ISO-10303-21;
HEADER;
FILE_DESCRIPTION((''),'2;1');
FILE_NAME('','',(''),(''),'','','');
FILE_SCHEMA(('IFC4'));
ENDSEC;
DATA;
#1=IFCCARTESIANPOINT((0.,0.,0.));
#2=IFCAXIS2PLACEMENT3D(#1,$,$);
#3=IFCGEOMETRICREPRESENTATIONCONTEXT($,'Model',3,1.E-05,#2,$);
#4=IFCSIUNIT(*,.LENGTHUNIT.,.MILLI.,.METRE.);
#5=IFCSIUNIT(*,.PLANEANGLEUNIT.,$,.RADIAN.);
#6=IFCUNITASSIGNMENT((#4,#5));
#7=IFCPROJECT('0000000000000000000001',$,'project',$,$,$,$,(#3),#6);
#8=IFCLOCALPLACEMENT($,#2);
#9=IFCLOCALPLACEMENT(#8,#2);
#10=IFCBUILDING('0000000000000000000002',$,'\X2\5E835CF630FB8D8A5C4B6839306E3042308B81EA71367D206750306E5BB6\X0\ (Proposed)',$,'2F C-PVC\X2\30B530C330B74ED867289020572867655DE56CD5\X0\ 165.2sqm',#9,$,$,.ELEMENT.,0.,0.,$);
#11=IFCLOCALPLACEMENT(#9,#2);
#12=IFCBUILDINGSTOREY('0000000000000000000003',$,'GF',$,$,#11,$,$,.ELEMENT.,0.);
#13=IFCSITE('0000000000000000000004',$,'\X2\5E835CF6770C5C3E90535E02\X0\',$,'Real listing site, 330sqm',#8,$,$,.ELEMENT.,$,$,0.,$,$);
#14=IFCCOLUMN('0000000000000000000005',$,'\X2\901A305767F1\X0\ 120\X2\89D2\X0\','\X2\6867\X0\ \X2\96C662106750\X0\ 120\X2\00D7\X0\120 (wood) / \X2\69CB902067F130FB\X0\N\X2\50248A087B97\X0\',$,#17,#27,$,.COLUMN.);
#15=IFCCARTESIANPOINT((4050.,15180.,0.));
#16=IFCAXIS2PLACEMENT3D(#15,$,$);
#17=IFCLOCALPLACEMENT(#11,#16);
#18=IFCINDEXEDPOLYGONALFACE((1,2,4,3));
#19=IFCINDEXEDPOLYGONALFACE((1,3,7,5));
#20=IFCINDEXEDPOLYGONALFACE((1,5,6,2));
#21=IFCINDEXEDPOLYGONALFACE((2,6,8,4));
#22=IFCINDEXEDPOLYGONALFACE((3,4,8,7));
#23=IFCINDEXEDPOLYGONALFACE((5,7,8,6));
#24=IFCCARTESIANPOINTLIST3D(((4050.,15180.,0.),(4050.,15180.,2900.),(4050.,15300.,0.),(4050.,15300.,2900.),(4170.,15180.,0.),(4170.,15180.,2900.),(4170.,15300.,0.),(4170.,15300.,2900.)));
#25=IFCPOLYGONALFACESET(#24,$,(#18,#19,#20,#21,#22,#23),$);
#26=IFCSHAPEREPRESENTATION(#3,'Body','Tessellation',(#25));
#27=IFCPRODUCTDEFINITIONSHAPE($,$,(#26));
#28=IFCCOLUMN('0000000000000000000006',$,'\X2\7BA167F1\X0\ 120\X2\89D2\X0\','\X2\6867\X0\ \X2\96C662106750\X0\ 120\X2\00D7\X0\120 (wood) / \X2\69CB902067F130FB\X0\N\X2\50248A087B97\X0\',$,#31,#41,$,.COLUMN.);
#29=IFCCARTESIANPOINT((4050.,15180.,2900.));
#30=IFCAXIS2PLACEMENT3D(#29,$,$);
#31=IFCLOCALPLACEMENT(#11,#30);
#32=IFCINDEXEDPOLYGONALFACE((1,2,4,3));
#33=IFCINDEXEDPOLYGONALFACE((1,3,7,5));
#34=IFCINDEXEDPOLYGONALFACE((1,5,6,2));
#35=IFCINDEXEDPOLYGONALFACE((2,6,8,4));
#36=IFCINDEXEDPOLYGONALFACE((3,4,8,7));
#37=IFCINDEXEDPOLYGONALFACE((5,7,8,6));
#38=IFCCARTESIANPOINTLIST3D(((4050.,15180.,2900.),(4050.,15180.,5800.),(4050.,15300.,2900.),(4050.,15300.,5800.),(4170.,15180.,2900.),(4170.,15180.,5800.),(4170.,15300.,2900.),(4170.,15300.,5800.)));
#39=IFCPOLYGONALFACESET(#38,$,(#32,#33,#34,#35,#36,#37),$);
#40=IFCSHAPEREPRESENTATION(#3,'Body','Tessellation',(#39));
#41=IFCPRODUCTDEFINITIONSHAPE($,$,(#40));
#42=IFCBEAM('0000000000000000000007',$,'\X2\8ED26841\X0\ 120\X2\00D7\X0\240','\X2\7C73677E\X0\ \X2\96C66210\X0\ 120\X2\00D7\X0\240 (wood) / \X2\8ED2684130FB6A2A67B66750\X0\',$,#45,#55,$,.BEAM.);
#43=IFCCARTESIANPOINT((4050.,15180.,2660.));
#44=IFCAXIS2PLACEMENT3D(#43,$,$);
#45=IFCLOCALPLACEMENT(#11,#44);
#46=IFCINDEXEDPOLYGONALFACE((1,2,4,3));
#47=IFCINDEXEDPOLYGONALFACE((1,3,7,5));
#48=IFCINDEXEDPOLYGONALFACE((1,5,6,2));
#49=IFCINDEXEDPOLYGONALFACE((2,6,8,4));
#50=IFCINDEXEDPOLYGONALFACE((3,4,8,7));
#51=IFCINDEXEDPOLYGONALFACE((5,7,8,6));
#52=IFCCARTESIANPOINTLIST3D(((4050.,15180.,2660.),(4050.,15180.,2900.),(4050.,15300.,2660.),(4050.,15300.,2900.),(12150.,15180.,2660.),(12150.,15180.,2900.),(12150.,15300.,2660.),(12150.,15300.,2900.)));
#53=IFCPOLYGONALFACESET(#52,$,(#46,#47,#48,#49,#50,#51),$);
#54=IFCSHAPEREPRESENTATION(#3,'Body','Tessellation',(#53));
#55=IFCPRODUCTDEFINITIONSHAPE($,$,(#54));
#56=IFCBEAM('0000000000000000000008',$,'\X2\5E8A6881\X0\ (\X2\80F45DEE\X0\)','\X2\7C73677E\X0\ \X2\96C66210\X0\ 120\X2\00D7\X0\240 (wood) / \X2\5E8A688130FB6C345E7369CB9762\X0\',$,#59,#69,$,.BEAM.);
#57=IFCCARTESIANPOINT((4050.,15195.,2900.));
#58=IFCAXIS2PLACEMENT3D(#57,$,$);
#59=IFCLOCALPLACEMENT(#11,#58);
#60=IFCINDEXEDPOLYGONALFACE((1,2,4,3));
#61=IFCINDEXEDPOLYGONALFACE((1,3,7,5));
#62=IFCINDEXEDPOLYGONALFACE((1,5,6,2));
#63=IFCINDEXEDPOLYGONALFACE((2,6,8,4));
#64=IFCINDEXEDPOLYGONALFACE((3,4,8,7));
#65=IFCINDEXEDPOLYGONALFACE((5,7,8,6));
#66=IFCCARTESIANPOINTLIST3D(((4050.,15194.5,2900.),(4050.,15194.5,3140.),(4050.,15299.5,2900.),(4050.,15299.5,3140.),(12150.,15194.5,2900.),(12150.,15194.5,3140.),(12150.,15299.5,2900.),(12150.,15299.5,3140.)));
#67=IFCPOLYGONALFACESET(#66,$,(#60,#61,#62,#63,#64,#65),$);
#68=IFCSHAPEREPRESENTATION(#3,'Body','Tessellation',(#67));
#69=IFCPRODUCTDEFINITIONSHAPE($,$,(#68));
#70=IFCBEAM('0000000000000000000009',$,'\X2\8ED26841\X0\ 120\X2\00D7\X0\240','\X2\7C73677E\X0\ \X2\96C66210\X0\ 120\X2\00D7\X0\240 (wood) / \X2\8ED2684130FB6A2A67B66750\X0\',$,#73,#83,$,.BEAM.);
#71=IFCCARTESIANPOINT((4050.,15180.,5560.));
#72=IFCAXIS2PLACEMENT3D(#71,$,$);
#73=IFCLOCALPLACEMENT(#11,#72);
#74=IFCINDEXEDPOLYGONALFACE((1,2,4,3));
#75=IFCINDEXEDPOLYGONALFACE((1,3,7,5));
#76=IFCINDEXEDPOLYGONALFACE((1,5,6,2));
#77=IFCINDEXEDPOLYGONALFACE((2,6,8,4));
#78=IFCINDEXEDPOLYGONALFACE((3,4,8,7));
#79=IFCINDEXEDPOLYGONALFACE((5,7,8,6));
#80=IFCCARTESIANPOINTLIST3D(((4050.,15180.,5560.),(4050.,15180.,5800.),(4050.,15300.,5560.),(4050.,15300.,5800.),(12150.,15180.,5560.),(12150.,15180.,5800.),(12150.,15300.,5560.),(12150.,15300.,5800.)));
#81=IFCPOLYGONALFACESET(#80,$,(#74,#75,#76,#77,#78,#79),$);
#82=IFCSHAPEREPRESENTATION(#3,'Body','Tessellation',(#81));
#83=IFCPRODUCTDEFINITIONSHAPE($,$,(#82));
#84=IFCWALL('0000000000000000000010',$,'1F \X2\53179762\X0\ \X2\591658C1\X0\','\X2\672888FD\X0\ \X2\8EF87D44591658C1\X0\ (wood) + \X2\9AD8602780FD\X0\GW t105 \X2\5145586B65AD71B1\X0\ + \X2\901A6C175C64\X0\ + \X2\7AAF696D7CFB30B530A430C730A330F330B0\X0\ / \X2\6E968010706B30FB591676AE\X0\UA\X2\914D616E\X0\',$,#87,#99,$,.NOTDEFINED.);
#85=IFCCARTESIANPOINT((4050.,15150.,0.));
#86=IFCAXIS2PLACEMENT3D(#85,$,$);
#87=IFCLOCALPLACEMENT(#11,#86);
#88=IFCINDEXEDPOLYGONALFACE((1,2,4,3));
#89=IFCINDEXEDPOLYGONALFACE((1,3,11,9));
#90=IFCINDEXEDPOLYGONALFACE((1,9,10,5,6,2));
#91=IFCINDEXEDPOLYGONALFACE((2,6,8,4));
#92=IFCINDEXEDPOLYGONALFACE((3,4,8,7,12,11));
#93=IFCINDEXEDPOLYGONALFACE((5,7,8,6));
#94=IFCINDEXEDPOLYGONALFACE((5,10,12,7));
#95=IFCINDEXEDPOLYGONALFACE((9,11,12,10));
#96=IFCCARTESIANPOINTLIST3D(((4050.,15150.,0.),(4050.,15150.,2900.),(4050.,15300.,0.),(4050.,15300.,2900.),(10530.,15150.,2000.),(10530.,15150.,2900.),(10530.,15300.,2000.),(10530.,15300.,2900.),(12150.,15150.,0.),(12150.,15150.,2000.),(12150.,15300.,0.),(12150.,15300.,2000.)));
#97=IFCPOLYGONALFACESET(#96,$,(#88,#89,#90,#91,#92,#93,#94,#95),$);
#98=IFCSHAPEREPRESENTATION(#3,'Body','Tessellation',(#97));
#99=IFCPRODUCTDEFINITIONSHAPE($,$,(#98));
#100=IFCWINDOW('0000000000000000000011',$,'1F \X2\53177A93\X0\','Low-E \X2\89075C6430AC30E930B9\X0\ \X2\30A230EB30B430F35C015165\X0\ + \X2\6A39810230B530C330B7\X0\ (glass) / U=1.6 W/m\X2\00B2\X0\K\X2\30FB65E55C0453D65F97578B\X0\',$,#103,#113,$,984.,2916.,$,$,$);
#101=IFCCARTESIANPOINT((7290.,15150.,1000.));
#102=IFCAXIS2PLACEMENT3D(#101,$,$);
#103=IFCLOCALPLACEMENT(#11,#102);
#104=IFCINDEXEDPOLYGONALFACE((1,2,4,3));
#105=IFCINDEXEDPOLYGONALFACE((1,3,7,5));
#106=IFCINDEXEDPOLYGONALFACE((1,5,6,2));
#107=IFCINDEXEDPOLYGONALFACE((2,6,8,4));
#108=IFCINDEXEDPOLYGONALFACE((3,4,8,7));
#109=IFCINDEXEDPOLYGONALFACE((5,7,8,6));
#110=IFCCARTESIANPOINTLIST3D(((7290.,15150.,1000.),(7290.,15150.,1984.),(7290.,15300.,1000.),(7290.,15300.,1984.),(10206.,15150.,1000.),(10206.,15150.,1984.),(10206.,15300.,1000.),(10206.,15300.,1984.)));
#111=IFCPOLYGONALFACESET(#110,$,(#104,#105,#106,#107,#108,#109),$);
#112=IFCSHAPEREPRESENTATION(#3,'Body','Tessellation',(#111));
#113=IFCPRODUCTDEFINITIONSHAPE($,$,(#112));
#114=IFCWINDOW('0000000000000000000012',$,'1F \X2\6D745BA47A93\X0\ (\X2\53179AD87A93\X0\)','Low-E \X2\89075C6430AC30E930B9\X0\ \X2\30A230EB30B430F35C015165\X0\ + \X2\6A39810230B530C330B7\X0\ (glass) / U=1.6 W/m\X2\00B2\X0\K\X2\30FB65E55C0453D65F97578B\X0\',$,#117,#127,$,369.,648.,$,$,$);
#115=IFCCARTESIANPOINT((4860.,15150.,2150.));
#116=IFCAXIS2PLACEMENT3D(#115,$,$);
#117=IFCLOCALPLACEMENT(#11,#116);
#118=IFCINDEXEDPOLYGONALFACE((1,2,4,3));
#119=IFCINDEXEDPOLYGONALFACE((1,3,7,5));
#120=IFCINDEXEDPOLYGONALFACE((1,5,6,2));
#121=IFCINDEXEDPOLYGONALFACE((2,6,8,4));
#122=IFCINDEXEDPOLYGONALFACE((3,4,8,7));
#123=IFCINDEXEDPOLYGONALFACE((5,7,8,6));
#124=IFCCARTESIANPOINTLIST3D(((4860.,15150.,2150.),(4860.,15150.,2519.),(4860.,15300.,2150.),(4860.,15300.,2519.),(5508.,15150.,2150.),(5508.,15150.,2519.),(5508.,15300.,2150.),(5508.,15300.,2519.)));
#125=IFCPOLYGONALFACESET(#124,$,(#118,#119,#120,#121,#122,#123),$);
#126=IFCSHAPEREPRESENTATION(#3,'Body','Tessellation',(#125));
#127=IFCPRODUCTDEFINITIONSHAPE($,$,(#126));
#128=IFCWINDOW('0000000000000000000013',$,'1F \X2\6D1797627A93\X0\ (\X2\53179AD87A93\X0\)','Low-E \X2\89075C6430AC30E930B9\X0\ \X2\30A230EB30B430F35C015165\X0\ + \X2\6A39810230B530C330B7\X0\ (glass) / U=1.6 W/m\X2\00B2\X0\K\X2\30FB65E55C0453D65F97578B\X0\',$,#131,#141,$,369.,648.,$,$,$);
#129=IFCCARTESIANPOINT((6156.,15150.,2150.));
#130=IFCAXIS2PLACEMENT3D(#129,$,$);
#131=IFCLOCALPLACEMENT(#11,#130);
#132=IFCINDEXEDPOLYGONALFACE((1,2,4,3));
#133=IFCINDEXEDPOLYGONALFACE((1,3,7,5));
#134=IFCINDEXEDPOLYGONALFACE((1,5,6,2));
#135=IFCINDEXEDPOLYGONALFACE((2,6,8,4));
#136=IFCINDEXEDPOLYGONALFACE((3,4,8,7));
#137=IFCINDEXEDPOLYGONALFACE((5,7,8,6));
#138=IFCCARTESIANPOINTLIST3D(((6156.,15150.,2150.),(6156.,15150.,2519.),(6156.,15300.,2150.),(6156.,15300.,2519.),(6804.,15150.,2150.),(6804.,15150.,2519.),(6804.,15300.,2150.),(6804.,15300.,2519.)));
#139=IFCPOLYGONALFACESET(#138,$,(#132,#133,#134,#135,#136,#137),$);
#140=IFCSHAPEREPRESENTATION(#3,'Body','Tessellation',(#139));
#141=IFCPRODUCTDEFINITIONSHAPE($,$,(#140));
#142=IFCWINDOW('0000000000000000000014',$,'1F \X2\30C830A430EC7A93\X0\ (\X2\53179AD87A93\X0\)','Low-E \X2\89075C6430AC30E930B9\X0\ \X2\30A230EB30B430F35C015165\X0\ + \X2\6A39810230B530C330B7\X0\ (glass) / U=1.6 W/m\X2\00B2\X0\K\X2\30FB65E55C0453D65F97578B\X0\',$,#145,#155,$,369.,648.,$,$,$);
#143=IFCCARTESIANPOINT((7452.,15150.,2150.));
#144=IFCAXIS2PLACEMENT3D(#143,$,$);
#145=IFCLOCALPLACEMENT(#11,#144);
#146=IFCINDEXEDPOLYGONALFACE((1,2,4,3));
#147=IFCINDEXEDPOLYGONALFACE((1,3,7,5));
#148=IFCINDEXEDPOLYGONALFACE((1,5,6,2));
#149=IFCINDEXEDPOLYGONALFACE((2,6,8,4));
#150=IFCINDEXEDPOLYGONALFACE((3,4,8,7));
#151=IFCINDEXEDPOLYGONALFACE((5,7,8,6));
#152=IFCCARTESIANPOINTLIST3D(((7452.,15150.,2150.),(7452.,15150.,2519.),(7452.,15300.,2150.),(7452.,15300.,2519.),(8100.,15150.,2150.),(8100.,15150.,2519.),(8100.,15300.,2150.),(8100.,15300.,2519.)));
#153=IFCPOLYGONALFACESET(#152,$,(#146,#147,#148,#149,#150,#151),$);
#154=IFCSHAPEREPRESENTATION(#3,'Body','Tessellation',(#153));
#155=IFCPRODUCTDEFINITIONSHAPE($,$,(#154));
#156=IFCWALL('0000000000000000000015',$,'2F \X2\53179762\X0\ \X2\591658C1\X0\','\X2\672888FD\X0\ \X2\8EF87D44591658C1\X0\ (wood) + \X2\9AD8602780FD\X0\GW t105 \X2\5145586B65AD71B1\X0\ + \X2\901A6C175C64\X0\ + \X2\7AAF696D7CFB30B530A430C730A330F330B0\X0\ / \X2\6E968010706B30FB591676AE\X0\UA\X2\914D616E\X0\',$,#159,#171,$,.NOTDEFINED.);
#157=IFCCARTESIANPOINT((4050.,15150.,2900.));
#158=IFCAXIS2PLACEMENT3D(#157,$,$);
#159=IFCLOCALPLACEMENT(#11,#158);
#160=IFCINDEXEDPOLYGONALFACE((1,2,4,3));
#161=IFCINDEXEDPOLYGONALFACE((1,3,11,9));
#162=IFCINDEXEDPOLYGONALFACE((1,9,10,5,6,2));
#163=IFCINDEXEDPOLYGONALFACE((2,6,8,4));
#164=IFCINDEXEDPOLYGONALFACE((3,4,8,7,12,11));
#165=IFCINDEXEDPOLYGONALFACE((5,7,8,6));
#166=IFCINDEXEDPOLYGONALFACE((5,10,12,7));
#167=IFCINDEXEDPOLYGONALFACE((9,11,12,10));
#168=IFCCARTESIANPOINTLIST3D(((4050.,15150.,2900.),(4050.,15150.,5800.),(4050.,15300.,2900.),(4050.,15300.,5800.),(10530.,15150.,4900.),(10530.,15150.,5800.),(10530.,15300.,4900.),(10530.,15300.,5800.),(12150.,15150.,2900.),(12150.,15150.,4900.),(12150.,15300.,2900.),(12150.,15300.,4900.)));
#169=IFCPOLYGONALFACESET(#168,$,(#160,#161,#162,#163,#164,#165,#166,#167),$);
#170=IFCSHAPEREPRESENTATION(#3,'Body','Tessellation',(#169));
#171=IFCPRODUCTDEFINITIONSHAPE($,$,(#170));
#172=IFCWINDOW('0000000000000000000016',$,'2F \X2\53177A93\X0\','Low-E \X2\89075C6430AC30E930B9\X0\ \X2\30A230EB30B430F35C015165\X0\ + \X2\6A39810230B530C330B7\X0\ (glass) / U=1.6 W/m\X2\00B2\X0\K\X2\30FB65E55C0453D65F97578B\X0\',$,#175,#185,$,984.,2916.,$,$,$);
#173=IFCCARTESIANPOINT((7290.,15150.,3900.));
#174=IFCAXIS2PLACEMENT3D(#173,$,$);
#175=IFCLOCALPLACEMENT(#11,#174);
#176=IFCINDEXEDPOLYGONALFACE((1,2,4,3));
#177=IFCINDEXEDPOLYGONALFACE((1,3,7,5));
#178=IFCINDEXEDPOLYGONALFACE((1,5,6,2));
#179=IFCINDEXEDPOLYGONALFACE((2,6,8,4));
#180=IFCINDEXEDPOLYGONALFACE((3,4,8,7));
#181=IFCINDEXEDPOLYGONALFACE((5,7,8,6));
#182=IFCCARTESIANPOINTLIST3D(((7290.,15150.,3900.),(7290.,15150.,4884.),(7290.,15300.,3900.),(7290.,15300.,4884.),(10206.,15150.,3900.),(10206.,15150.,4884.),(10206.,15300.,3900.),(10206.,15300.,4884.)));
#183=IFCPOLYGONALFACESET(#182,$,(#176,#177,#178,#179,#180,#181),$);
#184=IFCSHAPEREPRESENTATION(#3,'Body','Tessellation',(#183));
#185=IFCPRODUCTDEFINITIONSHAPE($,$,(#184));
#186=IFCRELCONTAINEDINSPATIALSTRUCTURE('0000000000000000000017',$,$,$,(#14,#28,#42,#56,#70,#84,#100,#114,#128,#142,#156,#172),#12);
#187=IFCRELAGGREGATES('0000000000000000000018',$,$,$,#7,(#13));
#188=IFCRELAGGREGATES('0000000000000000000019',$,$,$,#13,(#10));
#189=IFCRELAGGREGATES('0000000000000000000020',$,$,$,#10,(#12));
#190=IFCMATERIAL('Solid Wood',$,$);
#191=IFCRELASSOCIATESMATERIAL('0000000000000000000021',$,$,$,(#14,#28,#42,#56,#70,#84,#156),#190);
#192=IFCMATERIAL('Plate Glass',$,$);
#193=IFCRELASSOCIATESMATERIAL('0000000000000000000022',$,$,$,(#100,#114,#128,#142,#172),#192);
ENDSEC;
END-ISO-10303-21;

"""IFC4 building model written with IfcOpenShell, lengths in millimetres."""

from ifc_helpers import new_model, si_unit, frame, frame_2d, origin, place, context, project, spatial, rectangle, extrude, material, element, fill, save


model = new_model("IFC4")

# Units and contexts
model_context = context("Model", 3, precision=1e-05, world=origin())
ifc_project = project(units=[si_unit("LENGTHUNIT", "METRE", prefix="MILLI"), si_unit("PLANEANGLEUNIT", "RADIAN")], contexts=[model_context])

# Site, building, storey
site_placement = place(None, origin())
site = spatial("IfcSite", under=ifc_project, at=site_placement, Name="広島県尾道市", ObjectType="Real listing site, 330sqm", CompositionType="ELEMENT", RefElevation=0.0)
building_placement = place(site_placement, origin())
building = spatial("IfcBuilding", under=site, at=building_placement, Name="広島・越屋根のある自然素材の家 (Proposed)", ObjectType="2F C-PVCサッシ付木造在来工法 165.2sqm", CompositionType="ELEMENT", ElevationOfRefHeight=0.0, ElevationOfTerrain=0.0)
storey_placement = place(building_placement, origin())
storey = spatial("IfcBuildingStorey", under=building, at=storey_placement, Name="GF", CompositionType="ELEMENT", Elevation=0.0)

# Columns
ifc_material_1 = material(Name="Solid Wood")
column_1_placement = place(storey_placement, frame((4050.0, 15180.0, 0.0)))
element("IfcColumn", 1, at=column_1_placement, inside=storey, material=ifc_material_1, Name="通し柱 120角", Description="桧 集成材 120×120 (wood) / 構造柱・N値計算", PredefinedType="COLUMN", context=model_context, shape_type="SweptSolid", body=[
    extrude(rectangle(XDim=120.0, YDim=120.0, at=frame_2d((60.0, 60.0))), frame((4050.0, 15180.0, 0.0)), (0.0, 0.0, 1.0), 2900.0),
])
column_2_placement = place(storey_placement, frame((4050.0, 15180.0, 2900.0)))
element("IfcColumn", 2, at=column_2_placement, inside=storey, material=ifc_material_1, Name="管柱 120角", Description="桧 集成材 120×120 (wood) / 構造柱・N値計算", PredefinedType="COLUMN", context=model_context, shape_type="SweptSolid", body=[
    extrude(rectangle(XDim=120.0, YDim=120.0, at=frame_2d((60.0, 60.0))), frame((4050.0, 15180.0, 2900.0)), (0.0, 0.0, 1.0), 2900.0),
])

# Beams
beam_1_placement = place(storey_placement, frame((4050.0, 15180.0, 2660.0)))
element("IfcBeam", 3, at=beam_1_placement, inside=storey, material=ifc_material_1, Name="軒桁 120×240", Description="米松 集成 120×240 (wood) / 軒桁・横架材", PredefinedType="BEAM", context=model_context, shape_type="SweptSolid", body=[
    extrude(rectangle(XDim=8100.0, YDim=120.0, at=frame_2d((4050.0, 60.0))), frame((4050.0, 15180.0, 2660.0)), (0.0, 0.0, 1.0), 240.0),
])
beam_2_placement = place(storey_placement, frame((4050.0, 15195.0, 2900.0)))
element("IfcBeam", 4, at=beam_2_placement, inside=storey, material=ifc_material_1, Name="床梁 (胴差)", Description="米松 集成 120×240 (wood) / 床梁・水平構面", PredefinedType="BEAM", context=model_context, shape_type="SweptSolid", body=[
    extrude(rectangle(XDim=8100.0, YDim=105.0, at=frame_2d((4050.0, 52.0))), frame((4050.0, 15195.0, 2900.0)), (0.0, 0.0, 1.0), 240.0),
])
beam_3_placement = place(storey_placement, frame((4050.0, 15180.0, 5560.0)))
element("IfcBeam", 5, at=beam_3_placement, inside=storey, material=ifc_material_1, Name="軒桁 120×240", Description="米松 集成 120×240 (wood) / 軒桁・横架材", PredefinedType="BEAM", context=model_context, shape_type="SweptSolid", body=[
    extrude(rectangle(XDim=8100.0, YDim=120.0, at=frame_2d((4050.0, 60.0))), frame((4050.0, 15180.0, 5560.0)), (0.0, 0.0, 1.0), 240.0),
])

# Wall, openings, windows
wall_1_placement = place(storey_placement, frame((4050.0, 15150.0, 0.0)))
wall_1 = element("IfcWall", 6, at=wall_1_placement, inside=storey, material=ifc_material_1, Name="1F 北面 外壁", Description="木製 軸組外壁 (wood) + 高性能GW t105 充填断熱 + 通気層 + 窯業系サイディング / 準耐火・外皮UA配慮", PredefinedType="NOTDEFINED", context=model_context, shape_type="SweptSolid", body=[
    extrude(rectangle(XDim=8100.0, YDim=150.0, at=frame_2d((4050.0, 75.0))), frame((4050.0, 15150.0, 0.0)), (0.0, 0.0, 1.0), 2900.0),
])
opening_1_placement = place(storey_placement, frame((7290.0, 15150.0, 1000.0)))
opening_1 = element("IfcOpeningElement", 7, at=opening_1_placement, cuts=wall_1, PredefinedType="NOTDEFINED", context=model_context, shape_type="SweptSolid", body=[
    extrude(rectangle(XDim=2916.0, YDim=150.0, at=frame_2d((1458.0, 75.0))), frame((7290.0, 15150.0, 1000.0)), (0.0, 0.0, 1.0), 984.0),
])
opening_2_placement = place(storey_placement, frame((4860.0, 15150.0, 2150.0)))
opening_2 = element("IfcOpeningElement", 8, at=opening_2_placement, cuts=wall_1, PredefinedType="NOTDEFINED", context=model_context, shape_type="SweptSolid", body=[
    extrude(rectangle(XDim=648.0, YDim=150.0, at=frame_2d((324.0, 75.0))), frame((4860.0, 15150.0, 2150.0)), (0.0, 0.0, 1.0), 369.0),
])
opening_3_placement = place(storey_placement, frame((6156.0, 15150.0, 2150.0)))
opening_3 = element("IfcOpeningElement", 9, at=opening_3_placement, cuts=wall_1, PredefinedType="NOTDEFINED", context=model_context, shape_type="SweptSolid", body=[
    extrude(rectangle(XDim=648.0, YDim=150.0, at=frame_2d((324.0, 75.0))), frame((6156.0, 15150.0, 2150.0)), (0.0, 0.0, 1.0), 369.0),
])
opening_4_placement = place(storey_placement, frame((7452.0, 15150.0, 2150.0)))
opening_4 = element("IfcOpeningElement", 10, at=opening_4_placement, cuts=wall_1, PredefinedType="NOTDEFINED", context=model_context, shape_type="SweptSolid", body=[
    extrude(rectangle(XDim=648.0, YDim=150.0, at=frame_2d((324.0, 75.0))), frame((7452.0, 15150.0, 2150.0)), (0.0, 0.0, 1.0), 369.0),
])
ifc_material_2 = material(Name="Plate Glass")
window_1_placement = place(storey_placement, frame((7290.0, 15150.0, 1000.0)))
window_1 = element("IfcWindow", 11, at=window_1_placement, inside=storey, material=ifc_material_2, Name="1F 北窓", Description="Low-E 複層ガラス アルゴン封入 + 樹脂サッシ (glass) / U=1.6 W/m²K・日射取得型", OverallHeight=984.0, OverallWidth=2916.0, context=model_context, shape_type="SweptSolid", body=[
    extrude(rectangle(XDim=2916.0, YDim=150.0, at=frame_2d((1458.0, 75.0))), frame((7290.0, 15150.0, 1000.0)), (0.0, 0.0, 1.0), 984.0),
])
fill(opening_1, window_1)
window_2_placement = place(storey_placement, frame((4860.0, 15150.0, 2150.0)))
window_2 = element("IfcWindow", 12, at=window_2_placement, inside=storey, material=ifc_material_2, Name="1F 浴室窓 (北高窓)", Description="Low-E 複層ガラス アルゴン封入 + 樹脂サッシ (glass) / U=1.6 W/m²K・日射取得型", OverallHeight=369.0, OverallWidth=648.0, context=model_context, shape_type="SweptSolid", body=[
    extrude(rectangle(XDim=648.0, YDim=150.0, at=frame_2d((324.0, 75.0))), frame((4860.0, 15150.0, 2150.0)), (0.0, 0.0, 1.0), 369.0),
])
fill(opening_2, window_2)
window_3_placement = place(storey_placement, frame((6156.0, 15150.0, 2150.0)))
window_3 = element("IfcWindow", 13, at=window_3_placement, inside=storey, material=ifc_material_2, Name="1F 洗面窓 (北高窓)", Description="Low-E 複層ガラス アルゴン封入 + 樹脂サッシ (glass) / U=1.6 W/m²K・日射取得型", OverallHeight=369.0, OverallWidth=648.0, context=model_context, shape_type="SweptSolid", body=[
    extrude(rectangle(XDim=648.0, YDim=150.0, at=frame_2d((324.0, 75.0))), frame((6156.0, 15150.0, 2150.0)), (0.0, 0.0, 1.0), 369.0),
])
fill(opening_3, window_3)
window_4_placement = place(storey_placement, frame((7452.0, 15150.0, 2150.0)))
window_4 = element("IfcWindow", 14, at=window_4_placement, inside=storey, material=ifc_material_2, Name="1F トイレ窓 (北高窓)", Description="Low-E 複層ガラス アルゴン封入 + 樹脂サッシ (glass) / U=1.6 W/m²K・日射取得型", OverallHeight=369.0, OverallWidth=648.0, context=model_context, shape_type="SweptSolid", body=[
    extrude(rectangle(XDim=648.0, YDim=150.0, at=frame_2d((324.0, 75.0))), frame((7452.0, 15150.0, 2150.0)), (0.0, 0.0, 1.0), 369.0),
])
fill(opening_4, window_4)

# Wall, opening, window
wall_2_placement = place(storey_placement, frame((4050.0, 15150.0, 2900.0)))
wall_2 = element("IfcWall", 15, at=wall_2_placement, inside=storey, material=ifc_material_1, Name="2F 北面 外壁", Description="木製 軸組外壁 (wood) + 高性能GW t105 充填断熱 + 通気層 + 窯業系サイディング / 準耐火・外皮UA配慮", PredefinedType="NOTDEFINED", context=model_context, shape_type="SweptSolid", body=[
    extrude(rectangle(XDim=8100.0, YDim=150.0, at=frame_2d((4050.0, 75.0))), frame((4050.0, 15150.0, 2900.0)), (0.0, 0.0, 1.0), 2900.0),
])
opening_5_placement = place(storey_placement, frame((7290.0, 15150.0, 3900.0)))
opening_5 = element("IfcOpeningElement", 16, at=opening_5_placement, cuts=wall_2, PredefinedType="NOTDEFINED", context=model_context, shape_type="SweptSolid", body=[
    extrude(rectangle(XDim=2916.0, YDim=150.0, at=frame_2d((1458.0, 75.0))), frame((7290.0, 15150.0, 3900.0)), (0.0, 0.0, 1.0), 984.0),
])
window_5_placement = place(storey_placement, frame((7290.0, 15150.0, 3900.0)))
window_5 = element("IfcWindow", 17, at=window_5_placement, inside=storey, material=ifc_material_2, Name="2F 北窓", Description="Low-E 複層ガラス アルゴン封入 + 樹脂サッシ (glass) / U=1.6 W/m²K・日射取得型", OverallHeight=984.0, OverallWidth=2916.0, context=model_context, shape_type="SweptSolid", body=[
    extrude(rectangle(XDim=2916.0, YDim=150.0, at=frame_2d((1458.0, 75.0))), frame((7290.0, 15150.0, 3900.0)), (0.0, 0.0, 1.0), 984.0),
])
fill(opening_5, window_5)

save(model, "model.ifc")
